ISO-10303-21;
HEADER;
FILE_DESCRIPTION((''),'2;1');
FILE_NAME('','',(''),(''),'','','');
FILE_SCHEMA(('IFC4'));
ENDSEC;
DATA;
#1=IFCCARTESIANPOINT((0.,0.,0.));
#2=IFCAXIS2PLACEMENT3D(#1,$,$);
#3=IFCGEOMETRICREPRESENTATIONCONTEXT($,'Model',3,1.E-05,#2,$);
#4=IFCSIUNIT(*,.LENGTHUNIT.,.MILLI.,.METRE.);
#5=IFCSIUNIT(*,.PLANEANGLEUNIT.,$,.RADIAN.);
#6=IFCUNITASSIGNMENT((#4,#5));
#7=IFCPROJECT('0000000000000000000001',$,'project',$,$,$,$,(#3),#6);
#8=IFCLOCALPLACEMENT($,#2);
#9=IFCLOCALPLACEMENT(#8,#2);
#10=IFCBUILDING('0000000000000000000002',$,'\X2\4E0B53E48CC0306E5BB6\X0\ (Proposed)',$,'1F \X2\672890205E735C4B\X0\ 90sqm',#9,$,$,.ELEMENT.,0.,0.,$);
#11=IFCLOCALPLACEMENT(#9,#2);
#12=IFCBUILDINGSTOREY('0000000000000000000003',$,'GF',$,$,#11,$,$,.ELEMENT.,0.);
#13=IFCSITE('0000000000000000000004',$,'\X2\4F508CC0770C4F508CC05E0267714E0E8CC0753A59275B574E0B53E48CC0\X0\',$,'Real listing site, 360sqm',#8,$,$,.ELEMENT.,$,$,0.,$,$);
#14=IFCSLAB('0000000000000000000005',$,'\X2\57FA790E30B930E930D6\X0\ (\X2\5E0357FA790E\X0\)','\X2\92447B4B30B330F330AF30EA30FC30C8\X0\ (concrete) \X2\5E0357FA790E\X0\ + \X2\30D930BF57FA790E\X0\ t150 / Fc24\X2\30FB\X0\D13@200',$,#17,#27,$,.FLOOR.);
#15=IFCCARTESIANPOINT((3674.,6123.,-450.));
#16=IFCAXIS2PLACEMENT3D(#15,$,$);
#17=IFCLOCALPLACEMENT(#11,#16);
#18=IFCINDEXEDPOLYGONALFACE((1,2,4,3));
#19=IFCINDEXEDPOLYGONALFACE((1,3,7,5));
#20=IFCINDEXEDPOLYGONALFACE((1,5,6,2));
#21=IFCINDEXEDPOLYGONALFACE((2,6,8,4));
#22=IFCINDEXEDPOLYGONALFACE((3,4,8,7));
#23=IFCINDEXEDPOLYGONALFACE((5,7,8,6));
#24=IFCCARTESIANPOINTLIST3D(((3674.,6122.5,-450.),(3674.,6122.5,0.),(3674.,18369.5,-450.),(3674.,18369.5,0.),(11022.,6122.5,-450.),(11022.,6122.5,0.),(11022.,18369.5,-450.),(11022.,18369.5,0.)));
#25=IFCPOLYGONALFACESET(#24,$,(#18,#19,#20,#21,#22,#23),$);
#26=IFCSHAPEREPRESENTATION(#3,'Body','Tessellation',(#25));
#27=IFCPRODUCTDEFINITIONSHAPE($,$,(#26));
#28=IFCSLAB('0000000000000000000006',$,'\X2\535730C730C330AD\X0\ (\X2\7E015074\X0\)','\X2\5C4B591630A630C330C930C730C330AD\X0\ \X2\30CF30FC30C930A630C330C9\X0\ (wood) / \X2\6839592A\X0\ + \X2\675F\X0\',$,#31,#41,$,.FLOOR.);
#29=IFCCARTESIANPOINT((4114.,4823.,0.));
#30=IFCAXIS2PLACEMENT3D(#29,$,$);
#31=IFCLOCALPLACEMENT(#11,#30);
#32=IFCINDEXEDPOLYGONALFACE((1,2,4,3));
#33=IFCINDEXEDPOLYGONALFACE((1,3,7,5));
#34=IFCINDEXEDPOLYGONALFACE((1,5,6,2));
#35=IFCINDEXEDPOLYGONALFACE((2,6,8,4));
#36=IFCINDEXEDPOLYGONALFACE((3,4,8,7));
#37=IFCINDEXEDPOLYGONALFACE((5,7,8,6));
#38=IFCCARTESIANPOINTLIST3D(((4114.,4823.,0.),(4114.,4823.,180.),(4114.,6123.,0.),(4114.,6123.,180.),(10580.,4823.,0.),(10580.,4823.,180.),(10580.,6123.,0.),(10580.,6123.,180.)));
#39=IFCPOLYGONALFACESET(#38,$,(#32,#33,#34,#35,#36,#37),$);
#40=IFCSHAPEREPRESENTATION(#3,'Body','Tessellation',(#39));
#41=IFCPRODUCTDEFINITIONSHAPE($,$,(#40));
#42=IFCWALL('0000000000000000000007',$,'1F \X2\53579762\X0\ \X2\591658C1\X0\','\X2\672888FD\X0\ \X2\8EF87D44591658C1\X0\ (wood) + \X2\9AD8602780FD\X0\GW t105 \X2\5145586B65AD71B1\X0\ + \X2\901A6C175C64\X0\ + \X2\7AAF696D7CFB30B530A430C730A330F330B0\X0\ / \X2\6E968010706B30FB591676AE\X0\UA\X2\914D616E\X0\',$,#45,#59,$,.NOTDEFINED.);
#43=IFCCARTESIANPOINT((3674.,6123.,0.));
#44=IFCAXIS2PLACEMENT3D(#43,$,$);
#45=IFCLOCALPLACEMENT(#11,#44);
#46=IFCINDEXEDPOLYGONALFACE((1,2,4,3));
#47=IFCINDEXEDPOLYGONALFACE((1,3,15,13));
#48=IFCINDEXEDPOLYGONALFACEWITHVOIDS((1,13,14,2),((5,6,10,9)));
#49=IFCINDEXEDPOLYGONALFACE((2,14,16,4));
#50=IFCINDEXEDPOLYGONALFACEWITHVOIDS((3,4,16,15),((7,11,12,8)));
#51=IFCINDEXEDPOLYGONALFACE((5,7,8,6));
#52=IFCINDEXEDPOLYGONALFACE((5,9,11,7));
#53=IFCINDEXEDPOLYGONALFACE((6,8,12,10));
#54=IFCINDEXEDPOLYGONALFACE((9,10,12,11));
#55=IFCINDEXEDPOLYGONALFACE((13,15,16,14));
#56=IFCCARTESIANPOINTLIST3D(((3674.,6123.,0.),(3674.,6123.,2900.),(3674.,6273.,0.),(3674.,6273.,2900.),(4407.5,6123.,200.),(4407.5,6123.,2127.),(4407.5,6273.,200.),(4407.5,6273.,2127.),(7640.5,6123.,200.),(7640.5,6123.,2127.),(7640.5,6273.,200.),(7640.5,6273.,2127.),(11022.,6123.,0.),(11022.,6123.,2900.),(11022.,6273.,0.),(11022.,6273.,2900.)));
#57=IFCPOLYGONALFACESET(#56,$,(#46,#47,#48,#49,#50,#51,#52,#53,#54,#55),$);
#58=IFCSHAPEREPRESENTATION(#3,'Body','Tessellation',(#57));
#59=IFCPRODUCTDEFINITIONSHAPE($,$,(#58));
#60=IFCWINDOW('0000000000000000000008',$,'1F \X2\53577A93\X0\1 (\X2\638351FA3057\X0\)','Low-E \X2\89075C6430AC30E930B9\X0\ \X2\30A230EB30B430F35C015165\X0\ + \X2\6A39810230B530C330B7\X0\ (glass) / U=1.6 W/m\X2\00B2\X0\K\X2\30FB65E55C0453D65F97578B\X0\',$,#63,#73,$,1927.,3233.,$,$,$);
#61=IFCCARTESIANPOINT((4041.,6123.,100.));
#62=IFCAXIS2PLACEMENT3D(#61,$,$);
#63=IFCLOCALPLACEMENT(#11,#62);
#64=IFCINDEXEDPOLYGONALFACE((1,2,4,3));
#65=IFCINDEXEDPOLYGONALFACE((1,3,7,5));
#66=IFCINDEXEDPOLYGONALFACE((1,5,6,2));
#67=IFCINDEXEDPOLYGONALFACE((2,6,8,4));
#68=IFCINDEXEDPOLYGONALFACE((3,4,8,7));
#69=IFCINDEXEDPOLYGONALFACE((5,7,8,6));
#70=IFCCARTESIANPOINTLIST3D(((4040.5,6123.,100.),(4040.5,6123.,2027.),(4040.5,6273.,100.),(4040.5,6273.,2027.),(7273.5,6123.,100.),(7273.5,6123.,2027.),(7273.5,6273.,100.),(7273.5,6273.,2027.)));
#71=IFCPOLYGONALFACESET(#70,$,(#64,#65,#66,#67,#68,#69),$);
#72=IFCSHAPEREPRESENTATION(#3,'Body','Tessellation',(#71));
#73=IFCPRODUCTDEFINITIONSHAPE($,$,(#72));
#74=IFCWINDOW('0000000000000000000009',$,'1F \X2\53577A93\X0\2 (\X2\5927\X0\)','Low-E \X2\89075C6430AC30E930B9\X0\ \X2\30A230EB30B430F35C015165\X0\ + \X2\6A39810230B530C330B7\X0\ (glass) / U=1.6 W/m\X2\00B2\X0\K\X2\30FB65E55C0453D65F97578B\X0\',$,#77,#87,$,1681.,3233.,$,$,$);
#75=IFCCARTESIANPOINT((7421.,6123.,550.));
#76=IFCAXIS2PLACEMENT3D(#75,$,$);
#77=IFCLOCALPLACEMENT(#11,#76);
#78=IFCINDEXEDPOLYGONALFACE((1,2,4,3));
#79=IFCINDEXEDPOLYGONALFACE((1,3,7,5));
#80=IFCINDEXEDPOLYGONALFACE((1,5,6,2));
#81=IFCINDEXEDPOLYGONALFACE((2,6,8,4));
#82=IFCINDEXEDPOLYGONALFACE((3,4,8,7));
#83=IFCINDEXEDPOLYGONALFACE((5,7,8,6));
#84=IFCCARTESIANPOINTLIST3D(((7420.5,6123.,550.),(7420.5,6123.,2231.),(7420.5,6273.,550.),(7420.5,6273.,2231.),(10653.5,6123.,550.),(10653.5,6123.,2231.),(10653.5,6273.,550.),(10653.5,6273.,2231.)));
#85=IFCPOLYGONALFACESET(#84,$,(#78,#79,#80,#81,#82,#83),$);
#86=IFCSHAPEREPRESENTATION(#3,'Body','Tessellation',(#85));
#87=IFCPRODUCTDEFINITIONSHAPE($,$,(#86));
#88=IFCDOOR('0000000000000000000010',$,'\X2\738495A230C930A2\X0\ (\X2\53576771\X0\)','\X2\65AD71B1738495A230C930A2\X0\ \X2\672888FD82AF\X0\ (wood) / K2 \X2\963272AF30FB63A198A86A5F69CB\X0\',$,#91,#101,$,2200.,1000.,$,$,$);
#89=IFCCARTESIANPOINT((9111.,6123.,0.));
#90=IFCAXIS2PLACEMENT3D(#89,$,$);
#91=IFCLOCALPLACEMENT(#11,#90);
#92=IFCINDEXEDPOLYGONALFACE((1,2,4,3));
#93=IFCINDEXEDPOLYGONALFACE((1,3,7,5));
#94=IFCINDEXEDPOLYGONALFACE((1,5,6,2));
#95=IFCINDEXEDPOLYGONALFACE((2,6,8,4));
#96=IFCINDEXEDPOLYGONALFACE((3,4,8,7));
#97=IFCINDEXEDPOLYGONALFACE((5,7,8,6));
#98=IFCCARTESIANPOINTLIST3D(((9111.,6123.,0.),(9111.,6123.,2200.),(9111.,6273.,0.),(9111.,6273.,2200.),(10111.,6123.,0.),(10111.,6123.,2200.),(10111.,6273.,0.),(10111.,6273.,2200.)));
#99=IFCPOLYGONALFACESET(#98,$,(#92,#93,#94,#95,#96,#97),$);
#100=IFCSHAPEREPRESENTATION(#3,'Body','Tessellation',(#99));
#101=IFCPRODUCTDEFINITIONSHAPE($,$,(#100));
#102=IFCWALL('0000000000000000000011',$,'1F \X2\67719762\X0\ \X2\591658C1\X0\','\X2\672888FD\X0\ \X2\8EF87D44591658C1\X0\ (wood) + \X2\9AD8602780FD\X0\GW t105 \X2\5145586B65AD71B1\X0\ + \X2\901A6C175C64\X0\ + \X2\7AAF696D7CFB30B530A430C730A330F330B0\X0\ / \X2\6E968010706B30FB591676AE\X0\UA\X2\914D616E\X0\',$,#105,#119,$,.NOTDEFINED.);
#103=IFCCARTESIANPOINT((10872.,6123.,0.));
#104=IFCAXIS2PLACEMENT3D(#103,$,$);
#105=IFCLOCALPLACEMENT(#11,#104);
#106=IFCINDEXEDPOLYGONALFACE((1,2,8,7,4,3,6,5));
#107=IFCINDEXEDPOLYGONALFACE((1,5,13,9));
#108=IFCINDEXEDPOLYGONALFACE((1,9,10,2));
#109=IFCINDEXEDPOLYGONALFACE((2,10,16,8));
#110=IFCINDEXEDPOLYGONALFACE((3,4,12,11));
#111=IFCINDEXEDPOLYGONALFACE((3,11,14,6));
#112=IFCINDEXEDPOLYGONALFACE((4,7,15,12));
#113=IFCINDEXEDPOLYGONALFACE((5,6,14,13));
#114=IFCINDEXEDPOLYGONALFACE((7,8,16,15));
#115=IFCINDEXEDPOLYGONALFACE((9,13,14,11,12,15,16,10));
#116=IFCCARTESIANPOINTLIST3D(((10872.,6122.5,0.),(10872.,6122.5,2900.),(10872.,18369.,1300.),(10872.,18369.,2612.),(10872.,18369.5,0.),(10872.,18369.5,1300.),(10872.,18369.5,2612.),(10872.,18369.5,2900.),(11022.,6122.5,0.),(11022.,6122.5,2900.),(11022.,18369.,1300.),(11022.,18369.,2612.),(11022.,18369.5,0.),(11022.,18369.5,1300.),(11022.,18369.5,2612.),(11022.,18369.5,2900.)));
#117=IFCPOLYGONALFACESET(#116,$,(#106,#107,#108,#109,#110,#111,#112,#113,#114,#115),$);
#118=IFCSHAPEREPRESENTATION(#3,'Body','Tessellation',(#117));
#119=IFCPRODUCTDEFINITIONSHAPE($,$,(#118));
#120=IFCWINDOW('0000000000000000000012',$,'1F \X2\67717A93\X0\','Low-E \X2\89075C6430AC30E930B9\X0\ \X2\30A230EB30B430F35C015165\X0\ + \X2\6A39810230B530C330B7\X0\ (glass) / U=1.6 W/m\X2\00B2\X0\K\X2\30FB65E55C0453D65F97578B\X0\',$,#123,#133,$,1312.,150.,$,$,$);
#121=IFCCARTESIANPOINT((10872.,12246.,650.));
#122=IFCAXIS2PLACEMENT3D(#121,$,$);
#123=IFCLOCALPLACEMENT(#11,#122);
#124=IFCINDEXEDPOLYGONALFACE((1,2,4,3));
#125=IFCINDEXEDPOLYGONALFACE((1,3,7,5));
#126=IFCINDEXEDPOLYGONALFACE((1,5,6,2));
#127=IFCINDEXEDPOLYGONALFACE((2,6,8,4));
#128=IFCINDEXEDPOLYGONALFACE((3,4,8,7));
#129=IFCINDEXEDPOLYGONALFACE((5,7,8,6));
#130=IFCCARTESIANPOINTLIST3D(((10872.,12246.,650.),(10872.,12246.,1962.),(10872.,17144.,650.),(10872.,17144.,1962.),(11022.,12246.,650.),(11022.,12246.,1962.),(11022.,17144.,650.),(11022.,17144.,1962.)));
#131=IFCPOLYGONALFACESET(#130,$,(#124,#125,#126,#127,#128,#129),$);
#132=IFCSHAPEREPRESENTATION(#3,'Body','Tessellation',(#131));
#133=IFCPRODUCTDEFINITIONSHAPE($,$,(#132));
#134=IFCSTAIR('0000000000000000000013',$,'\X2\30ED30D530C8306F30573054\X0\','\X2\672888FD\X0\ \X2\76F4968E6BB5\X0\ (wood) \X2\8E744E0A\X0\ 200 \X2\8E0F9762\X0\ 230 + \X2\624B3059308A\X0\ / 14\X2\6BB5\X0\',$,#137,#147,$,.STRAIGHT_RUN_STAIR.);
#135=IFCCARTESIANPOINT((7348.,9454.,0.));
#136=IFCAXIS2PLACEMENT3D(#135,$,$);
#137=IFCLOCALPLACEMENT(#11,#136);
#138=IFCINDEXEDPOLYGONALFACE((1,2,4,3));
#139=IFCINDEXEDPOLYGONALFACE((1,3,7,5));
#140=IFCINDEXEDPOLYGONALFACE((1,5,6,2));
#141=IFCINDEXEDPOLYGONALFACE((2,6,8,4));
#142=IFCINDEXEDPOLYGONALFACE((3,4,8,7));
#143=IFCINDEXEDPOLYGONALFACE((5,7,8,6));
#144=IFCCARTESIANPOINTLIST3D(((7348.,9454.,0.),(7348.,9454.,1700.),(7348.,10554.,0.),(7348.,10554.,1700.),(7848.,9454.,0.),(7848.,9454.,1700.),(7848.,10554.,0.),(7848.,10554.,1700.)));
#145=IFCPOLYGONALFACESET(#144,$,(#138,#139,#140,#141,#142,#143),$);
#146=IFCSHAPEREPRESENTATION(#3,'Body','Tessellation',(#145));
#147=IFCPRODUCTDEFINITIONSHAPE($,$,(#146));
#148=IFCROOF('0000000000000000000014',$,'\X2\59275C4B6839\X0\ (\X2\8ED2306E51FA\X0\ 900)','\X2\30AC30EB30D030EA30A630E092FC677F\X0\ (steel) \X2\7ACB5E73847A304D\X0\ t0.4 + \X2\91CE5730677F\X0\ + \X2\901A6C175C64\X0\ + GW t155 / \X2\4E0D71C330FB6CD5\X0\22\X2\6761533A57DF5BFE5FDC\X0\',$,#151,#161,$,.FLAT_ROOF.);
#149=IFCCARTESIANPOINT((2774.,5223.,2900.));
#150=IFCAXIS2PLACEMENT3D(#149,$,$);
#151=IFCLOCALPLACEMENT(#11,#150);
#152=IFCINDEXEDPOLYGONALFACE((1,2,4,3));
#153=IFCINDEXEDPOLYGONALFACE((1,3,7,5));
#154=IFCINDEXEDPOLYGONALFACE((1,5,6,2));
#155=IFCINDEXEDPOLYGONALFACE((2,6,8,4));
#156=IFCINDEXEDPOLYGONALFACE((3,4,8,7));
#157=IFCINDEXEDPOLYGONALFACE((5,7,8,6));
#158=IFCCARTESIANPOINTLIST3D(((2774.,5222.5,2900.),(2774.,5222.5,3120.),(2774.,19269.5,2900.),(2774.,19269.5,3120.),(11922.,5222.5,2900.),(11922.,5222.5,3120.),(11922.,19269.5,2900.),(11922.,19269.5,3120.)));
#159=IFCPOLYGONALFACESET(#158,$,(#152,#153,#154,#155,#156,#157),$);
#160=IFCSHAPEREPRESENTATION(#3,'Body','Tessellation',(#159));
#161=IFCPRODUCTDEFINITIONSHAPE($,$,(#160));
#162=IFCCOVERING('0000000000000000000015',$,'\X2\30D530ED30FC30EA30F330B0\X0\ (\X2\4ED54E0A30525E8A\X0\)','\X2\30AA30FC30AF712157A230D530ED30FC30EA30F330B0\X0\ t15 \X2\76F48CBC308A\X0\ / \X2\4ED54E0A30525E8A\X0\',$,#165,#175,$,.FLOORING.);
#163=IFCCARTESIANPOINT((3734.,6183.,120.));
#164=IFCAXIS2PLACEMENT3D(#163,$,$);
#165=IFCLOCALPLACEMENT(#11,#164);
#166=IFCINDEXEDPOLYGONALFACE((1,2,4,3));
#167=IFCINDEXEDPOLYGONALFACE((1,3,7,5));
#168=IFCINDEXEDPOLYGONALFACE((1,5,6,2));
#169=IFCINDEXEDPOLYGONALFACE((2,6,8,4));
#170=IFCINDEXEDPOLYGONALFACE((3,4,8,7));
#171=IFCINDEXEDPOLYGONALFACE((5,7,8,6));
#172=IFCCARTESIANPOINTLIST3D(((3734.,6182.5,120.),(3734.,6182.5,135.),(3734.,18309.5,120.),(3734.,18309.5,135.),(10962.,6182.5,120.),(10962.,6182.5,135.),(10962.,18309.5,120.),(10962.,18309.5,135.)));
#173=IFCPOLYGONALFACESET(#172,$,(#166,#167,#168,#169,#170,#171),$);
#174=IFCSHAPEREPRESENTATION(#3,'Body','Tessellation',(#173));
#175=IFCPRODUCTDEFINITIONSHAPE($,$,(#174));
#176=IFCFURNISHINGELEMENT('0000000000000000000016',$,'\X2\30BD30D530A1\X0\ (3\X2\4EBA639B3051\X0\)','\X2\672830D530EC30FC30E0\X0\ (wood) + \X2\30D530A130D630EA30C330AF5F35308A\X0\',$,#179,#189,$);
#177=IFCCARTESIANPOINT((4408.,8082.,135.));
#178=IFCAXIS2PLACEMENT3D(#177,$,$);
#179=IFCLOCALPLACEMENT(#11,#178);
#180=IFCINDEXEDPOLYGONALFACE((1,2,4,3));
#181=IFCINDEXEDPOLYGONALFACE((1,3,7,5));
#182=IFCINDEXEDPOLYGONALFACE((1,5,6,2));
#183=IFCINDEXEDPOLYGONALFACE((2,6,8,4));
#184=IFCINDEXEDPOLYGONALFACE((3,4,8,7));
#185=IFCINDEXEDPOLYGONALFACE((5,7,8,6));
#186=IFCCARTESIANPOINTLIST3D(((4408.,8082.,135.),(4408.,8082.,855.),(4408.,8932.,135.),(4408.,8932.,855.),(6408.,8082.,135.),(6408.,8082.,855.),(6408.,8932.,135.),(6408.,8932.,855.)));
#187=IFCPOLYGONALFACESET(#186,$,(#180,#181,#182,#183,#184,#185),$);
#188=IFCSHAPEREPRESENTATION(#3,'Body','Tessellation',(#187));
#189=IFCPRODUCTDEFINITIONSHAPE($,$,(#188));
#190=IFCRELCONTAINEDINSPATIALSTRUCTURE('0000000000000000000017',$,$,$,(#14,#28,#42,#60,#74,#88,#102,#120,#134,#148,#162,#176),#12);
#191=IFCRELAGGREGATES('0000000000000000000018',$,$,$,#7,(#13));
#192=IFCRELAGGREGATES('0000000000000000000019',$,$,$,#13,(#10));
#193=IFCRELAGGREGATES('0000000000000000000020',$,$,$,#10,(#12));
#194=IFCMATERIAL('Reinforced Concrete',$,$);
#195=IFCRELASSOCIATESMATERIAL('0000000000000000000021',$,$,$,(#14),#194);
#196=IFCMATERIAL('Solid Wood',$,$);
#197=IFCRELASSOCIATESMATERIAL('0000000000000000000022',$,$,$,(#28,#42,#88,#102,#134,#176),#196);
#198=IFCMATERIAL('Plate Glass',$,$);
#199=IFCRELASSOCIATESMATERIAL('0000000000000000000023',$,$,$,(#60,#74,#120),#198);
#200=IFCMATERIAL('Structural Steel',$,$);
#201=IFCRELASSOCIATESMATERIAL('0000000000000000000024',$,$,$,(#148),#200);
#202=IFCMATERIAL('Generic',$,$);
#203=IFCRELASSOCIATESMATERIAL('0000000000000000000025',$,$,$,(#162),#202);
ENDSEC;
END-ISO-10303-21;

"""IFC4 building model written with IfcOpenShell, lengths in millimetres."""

from ifc_helpers import new_model, si_unit, frame, frame_2d, origin, place, context, project, spatial, rectangle, extrude, material, element, fill, save


model = new_model("IFC4")

# Units and contexts
model_context = context("Model", 3, precision=1e-05, world=origin())
ifc_project = project(units=[si_unit("LENGTHUNIT", "METRE", prefix="MILLI"), si_unit("PLANEANGLEUNIT", "RADIAN")], contexts=[model_context])

# Site, building, storey
site_placement = place(None, origin())
site = spatial("IfcSite", under=ifc_project, at=site_placement, Name="佐賀県佐賀市東与賀町大字下古賀", ObjectType="Real listing site, 360sqm", CompositionType="ELEMENT", RefElevation=0.0)
building_placement = place(site_placement, origin())
building = spatial("IfcBuilding", under=site, at=building_placement, Name="下古賀の家 (Proposed)", ObjectType="1F 木造平屋 90sqm", CompositionType="ELEMENT", ElevationOfRefHeight=0.0, ElevationOfTerrain=0.0)
storey_placement = place(building_placement, origin())
storey = spatial("IfcBuildingStorey", under=building, at=storey_placement, Name="GF", CompositionType="ELEMENT", Elevation=0.0)

# Slabs
ifc_material_1 = material(Name="Reinforced Concrete")
slab_1_placement = place(storey_placement, frame((3674.0, 6123.0, -450.0)))
element("IfcSlab", 1, at=slab_1_placement, inside=storey, material=ifc_material_1, Name="基礎スラブ (布基礎)", Description="鉄筋コンクリート (concrete) 布基礎 + ベタ基礎 t150 / Fc24・D13@200", PredefinedType="FLOOR", context=model_context, shape_type="SweptSolid", body=[
    extrude(rectangle(XDim=7348.0, YDim=12247.0, at=frame_2d((3674.0, 6123.0))), frame((3674.0, 6123.0, -450.0)), (0.0, 0.0, 1.0), 450.0),
])
ifc_material_2 = material(Name="Solid Wood")
slab_2_placement = place(storey_placement, frame((4114.0, 4823.0, 0.0)))
element("IfcSlab", 2, at=slab_2_placement, inside=storey, material=ifc_material_2, Name="南デッキ (縁側)", Description="屋外ウッドデッキ ハードウッド (wood) / 根太 + 束", PredefinedType="FLOOR", context=model_context, shape_type="SweptSolid", body=[
    extrude(rectangle(XDim=6466.0, YDim=1300.0, at=frame_2d((3233.0, 650.0))), frame((4114.0, 4823.0, 0.0)), (0.0, 0.0, 1.0), 180.0),
])

# Wall, openings, windows, door
wall_1_placement = place(storey_placement, frame((3674.0, 6123.0, 0.0)))
wall_1 = element("IfcWall", 3, at=wall_1_placement, inside=storey, material=ifc_material_2, Name="1F 南面 外壁", Description="木製 軸組外壁 (wood) + 高性能GW t105 充填断熱 + 通気層 + 窯業系サイディング / 準耐火・外皮UA配慮", PredefinedType="NOTDEFINED", context=model_context, shape_type="SweptSolid", body=[
    extrude(rectangle(XDim=7348.0, YDim=150.0, at=frame_2d((3674.0, 75.0))), frame((3674.0, 6123.0, 0.0)), (0.0, 0.0, 1.0), 2900.0),
])
opening_1_placement = place(storey_placement, frame((4041.0, 6123.0, 100.0)))
opening_1 = element("IfcOpeningElement", 4, at=opening_1_placement, cuts=wall_1, PredefinedType="NOTDEFINED", context=model_context, shape_type="SweptSolid", body=[
    extrude(rectangle(XDim=3233.0, YDim=150.0, at=frame_2d((1616.0, 75.0))), frame((4041.0, 6123.0, 100.0)), (0.0, 0.0, 1.0), 1927.0),
])
opening_2_placement = place(storey_placement, frame((7421.0, 6123.0, 550.0)))
opening_2 = element("IfcOpeningElement", 5, at=opening_2_placement, cuts=wall_1, PredefinedType="NOTDEFINED", context=model_context, shape_type="SweptSolid", body=[
    extrude(rectangle(XDim=3233.0, YDim=150.0, at=frame_2d((1616.0, 75.0))), frame((7421.0, 6123.0, 550.0)), (0.0, 0.0, 1.0), 1681.0),
])
opening_3_placement = place(storey_placement, frame((9111.0, 6123.0, 0.0)))
opening_3 = element("IfcOpeningElement", 6, at=opening_3_placement, cuts=wall_1, PredefinedType="NOTDEFINED", context=model_context, shape_type="SweptSolid", body=[
    extrude(rectangle(XDim=1000.0, YDim=150.0, at=frame_2d((500.0, 75.0))), frame((9111.0, 6123.0, 0.0)), (0.0, 0.0, 1.0), 2200.0),
])
ifc_material_3 = material(Name="Plate Glass")
window_1_placement = place(storey_placement, frame((4041.0, 6123.0, 100.0)))
window_1 = element("IfcWindow", 7, at=window_1_placement, inside=storey, material=ifc_material_3, Name="1F 南窓1 (掃出し)", Description="Low-E 複層ガラス アルゴン封入 + 樹脂サッシ (glass) / U=1.6 W/m²K・日射取得型", OverallHeight=1927.0, OverallWidth=3233.0, context=model_context, shape_type="SweptSolid", body=[
    extrude(rectangle(XDim=3233.0, YDim=150.0, at=frame_2d((1616.0, 75.0))), frame((4041.0, 6123.0, 100.0)), (0.0, 0.0, 1.0), 1927.0),
])
fill(opening_1, window_1)
window_2_placement = place(storey_placement, frame((7421.0, 6123.0, 550.0)))
window_2 = element("IfcWindow", 8, at=window_2_placement, inside=storey, material=ifc_material_3, Name="1F 南窓2 (大)", Description="Low-E 複層ガラス アルゴン封入 + 樹脂サッシ (glass) / U=1.6 W/m²K・日射取得型", OverallHeight=1681.0, OverallWidth=3233.0, context=model_context, shape_type="SweptSolid", body=[
    extrude(rectangle(XDim=3233.0, YDim=150.0, at=frame_2d((1616.0, 75.0))), frame((7421.0, 6123.0, 550.0)), (0.0, 0.0, 1.0), 1681.0),
])
fill(opening_2, window_2)
door_placement = place(storey_placement, frame((9111.0, 6123.0, 0.0)))
door = element("IfcDoor", 9, at=door_placement, inside=storey, material=ifc_material_2, Name="玄関ドア (南東)", Description="断熱玄関ドア 木製芯 (wood) / K2 防犯・採風機構", OverallHeight=2200.0, OverallWidth=1000.0, context=model_context, shape_type="SweptSolid", body=[
    extrude(rectangle(XDim=1000.0, YDim=150.0, at=frame_2d((500.0, 75.0))), frame((9111.0, 6123.0, 0.0)), (0.0, 0.0, 1.0), 2200.0),
])
fill(opening_3, door)

# Wall, opening, window
wall_2_placement = place(storey_placement, frame((10872.0, 6123.0, 0.0)))
wall_2 = element("IfcWall", 10, at=wall_2_placement, inside=storey, material=ifc_material_2, Name="1F 東面 外壁", Description="木製 軸組外壁 (wood) + 高性能GW t105 充填断熱 + 通気層 + 窯業系サイディング / 準耐火・外皮UA配慮", PredefinedType="NOTDEFINED", context=model_context, shape_type="SweptSolid", body=[
    extrude(rectangle(XDim=150.0, YDim=12247.0, at=frame_2d((75.0, 6123.0))), frame((10872.0, 6123.0, 0.0)), (0.0, 0.0, 1.0), 2900.0),
])
opening_4_placement = place(storey_placement, frame((10872.0, 12246.0, 650.0)))
opening_4 = element("IfcOpeningElement", 11, at=opening_4_placement, cuts=wall_2, PredefinedType="NOTDEFINED", context=model_context, shape_type="SweptSolid", body=[
    extrude(rectangle(XDim=150.0, YDim=4898.0, at=frame_2d((75.0, 2449.0))), frame((10872.0, 12246.0, 650.0)), (0.0, 0.0, 1.0), 1312.0),
])
window_3_placement = place(storey_placement, frame((10872.0, 12246.0, 650.0)))
window_3 = element("IfcWindow", 12, at=window_3_placement, inside=storey, material=ifc_material_3, Name="1F 東窓", Description="Low-E 複層ガラス アルゴン封入 + 樹脂サッシ (glass) / U=1.6 W/m²K・日射取得型", OverallHeight=1312.0, OverallWidth=150.0, context=model_context, shape_type="SweptSolid", body=[
    extrude(rectangle(XDim=150.0, YDim=4898.0, at=frame_2d((75.0, 2449.0))), frame((10872.0, 12246.0, 650.0)), (0.0, 0.0, 1.0), 1312.0),
])
fill(opening_4, window_3)

# Stair
stair_placement = place(storey_placement, frame((7348.0, 9454.0, 0.0)))
element("IfcStair", 13, at=stair_placement, inside=storey, material=ifc_material_2, Name="ロフトはしご", Description="木製 直階段 (wood) 蹴上 200 踏面 230 + 手すり / 14段", PredefinedType="STRAIGHT_RUN_STAIR", context=model_context, shape_type="SweptSolid", body=[
    extrude(rectangle(XDim=500.0, YDim=1100.0, at=frame_2d((250.0, 550.0))), frame((7348.0, 9454.0, 0.0)), (0.0, 0.0, 1.0), 1700.0),
])

# Roof
ifc_material_4 = material(Name="Structural Steel")
roof_placement = place(storey_placement, frame((2774.0, 5223.0, 2900.0)))
element("IfcRoof", 14, at=roof_placement, inside=storey, material=ifc_material_4, Name="大屋根 (軒の出 900)", Description="ガルバリウム鋼板 (steel) 立平葺き t0.4 + 野地板 + 通気層 + GW t155 / 不燃・法22条区域対応", PredefinedType="FLAT_ROOF", context=model_context, shape_type="SweptSolid", body=[
    extrude(rectangle(XDim=9148.0, YDim=14047.0, at=frame_2d((4574.0, 7023.0))), frame((2774.0, 5223.0, 2900.0)), (0.0, 0.0, 1.0), 220.0),
])

# Covering
ifc_material_5 = material(Name="Generic")
covering_placement = place(storey_placement, frame((3734.0, 6183.0, 120.0)))
element("IfcCovering", 15, at=covering_placement, inside=storey, material=ifc_material_5, Name="フローリング (仕上げ床)", Description="オーク無垢フローリング t15 直貼り / 仕上げ床", PredefinedType="FLOORING", context=model_context, shape_type="SweptSolid", body=[
    extrude(rectangle(XDim=7228.0, YDim=12127.0, at=frame_2d((3614.0, 6063.0))), frame((3734.0, 6183.0, 120.0)), (0.0, 0.0, 1.0), 15.0),
])

# Furnishing element
furnishing_1_placement = place(storey_placement, frame((4408.0, 8082.0, 135.0)))
element("IfcFurnishingElement", 16, at=furnishing_1_placement, inside=storey, material=ifc_material_2, Name="ソファ (3人掛け)", Description="木フレーム (wood) + ファブリック張り", context=model_context, shape_type="SweptSolid", body=[
    extrude(rectangle(XDim=2000.0, YDim=850.0, at=frame_2d((1000.0, 425.0))), frame((4408.0, 8082.0, 135.0)), (0.0, 0.0, 1.0), 720.0),
])

save(model, "model.ifc")
